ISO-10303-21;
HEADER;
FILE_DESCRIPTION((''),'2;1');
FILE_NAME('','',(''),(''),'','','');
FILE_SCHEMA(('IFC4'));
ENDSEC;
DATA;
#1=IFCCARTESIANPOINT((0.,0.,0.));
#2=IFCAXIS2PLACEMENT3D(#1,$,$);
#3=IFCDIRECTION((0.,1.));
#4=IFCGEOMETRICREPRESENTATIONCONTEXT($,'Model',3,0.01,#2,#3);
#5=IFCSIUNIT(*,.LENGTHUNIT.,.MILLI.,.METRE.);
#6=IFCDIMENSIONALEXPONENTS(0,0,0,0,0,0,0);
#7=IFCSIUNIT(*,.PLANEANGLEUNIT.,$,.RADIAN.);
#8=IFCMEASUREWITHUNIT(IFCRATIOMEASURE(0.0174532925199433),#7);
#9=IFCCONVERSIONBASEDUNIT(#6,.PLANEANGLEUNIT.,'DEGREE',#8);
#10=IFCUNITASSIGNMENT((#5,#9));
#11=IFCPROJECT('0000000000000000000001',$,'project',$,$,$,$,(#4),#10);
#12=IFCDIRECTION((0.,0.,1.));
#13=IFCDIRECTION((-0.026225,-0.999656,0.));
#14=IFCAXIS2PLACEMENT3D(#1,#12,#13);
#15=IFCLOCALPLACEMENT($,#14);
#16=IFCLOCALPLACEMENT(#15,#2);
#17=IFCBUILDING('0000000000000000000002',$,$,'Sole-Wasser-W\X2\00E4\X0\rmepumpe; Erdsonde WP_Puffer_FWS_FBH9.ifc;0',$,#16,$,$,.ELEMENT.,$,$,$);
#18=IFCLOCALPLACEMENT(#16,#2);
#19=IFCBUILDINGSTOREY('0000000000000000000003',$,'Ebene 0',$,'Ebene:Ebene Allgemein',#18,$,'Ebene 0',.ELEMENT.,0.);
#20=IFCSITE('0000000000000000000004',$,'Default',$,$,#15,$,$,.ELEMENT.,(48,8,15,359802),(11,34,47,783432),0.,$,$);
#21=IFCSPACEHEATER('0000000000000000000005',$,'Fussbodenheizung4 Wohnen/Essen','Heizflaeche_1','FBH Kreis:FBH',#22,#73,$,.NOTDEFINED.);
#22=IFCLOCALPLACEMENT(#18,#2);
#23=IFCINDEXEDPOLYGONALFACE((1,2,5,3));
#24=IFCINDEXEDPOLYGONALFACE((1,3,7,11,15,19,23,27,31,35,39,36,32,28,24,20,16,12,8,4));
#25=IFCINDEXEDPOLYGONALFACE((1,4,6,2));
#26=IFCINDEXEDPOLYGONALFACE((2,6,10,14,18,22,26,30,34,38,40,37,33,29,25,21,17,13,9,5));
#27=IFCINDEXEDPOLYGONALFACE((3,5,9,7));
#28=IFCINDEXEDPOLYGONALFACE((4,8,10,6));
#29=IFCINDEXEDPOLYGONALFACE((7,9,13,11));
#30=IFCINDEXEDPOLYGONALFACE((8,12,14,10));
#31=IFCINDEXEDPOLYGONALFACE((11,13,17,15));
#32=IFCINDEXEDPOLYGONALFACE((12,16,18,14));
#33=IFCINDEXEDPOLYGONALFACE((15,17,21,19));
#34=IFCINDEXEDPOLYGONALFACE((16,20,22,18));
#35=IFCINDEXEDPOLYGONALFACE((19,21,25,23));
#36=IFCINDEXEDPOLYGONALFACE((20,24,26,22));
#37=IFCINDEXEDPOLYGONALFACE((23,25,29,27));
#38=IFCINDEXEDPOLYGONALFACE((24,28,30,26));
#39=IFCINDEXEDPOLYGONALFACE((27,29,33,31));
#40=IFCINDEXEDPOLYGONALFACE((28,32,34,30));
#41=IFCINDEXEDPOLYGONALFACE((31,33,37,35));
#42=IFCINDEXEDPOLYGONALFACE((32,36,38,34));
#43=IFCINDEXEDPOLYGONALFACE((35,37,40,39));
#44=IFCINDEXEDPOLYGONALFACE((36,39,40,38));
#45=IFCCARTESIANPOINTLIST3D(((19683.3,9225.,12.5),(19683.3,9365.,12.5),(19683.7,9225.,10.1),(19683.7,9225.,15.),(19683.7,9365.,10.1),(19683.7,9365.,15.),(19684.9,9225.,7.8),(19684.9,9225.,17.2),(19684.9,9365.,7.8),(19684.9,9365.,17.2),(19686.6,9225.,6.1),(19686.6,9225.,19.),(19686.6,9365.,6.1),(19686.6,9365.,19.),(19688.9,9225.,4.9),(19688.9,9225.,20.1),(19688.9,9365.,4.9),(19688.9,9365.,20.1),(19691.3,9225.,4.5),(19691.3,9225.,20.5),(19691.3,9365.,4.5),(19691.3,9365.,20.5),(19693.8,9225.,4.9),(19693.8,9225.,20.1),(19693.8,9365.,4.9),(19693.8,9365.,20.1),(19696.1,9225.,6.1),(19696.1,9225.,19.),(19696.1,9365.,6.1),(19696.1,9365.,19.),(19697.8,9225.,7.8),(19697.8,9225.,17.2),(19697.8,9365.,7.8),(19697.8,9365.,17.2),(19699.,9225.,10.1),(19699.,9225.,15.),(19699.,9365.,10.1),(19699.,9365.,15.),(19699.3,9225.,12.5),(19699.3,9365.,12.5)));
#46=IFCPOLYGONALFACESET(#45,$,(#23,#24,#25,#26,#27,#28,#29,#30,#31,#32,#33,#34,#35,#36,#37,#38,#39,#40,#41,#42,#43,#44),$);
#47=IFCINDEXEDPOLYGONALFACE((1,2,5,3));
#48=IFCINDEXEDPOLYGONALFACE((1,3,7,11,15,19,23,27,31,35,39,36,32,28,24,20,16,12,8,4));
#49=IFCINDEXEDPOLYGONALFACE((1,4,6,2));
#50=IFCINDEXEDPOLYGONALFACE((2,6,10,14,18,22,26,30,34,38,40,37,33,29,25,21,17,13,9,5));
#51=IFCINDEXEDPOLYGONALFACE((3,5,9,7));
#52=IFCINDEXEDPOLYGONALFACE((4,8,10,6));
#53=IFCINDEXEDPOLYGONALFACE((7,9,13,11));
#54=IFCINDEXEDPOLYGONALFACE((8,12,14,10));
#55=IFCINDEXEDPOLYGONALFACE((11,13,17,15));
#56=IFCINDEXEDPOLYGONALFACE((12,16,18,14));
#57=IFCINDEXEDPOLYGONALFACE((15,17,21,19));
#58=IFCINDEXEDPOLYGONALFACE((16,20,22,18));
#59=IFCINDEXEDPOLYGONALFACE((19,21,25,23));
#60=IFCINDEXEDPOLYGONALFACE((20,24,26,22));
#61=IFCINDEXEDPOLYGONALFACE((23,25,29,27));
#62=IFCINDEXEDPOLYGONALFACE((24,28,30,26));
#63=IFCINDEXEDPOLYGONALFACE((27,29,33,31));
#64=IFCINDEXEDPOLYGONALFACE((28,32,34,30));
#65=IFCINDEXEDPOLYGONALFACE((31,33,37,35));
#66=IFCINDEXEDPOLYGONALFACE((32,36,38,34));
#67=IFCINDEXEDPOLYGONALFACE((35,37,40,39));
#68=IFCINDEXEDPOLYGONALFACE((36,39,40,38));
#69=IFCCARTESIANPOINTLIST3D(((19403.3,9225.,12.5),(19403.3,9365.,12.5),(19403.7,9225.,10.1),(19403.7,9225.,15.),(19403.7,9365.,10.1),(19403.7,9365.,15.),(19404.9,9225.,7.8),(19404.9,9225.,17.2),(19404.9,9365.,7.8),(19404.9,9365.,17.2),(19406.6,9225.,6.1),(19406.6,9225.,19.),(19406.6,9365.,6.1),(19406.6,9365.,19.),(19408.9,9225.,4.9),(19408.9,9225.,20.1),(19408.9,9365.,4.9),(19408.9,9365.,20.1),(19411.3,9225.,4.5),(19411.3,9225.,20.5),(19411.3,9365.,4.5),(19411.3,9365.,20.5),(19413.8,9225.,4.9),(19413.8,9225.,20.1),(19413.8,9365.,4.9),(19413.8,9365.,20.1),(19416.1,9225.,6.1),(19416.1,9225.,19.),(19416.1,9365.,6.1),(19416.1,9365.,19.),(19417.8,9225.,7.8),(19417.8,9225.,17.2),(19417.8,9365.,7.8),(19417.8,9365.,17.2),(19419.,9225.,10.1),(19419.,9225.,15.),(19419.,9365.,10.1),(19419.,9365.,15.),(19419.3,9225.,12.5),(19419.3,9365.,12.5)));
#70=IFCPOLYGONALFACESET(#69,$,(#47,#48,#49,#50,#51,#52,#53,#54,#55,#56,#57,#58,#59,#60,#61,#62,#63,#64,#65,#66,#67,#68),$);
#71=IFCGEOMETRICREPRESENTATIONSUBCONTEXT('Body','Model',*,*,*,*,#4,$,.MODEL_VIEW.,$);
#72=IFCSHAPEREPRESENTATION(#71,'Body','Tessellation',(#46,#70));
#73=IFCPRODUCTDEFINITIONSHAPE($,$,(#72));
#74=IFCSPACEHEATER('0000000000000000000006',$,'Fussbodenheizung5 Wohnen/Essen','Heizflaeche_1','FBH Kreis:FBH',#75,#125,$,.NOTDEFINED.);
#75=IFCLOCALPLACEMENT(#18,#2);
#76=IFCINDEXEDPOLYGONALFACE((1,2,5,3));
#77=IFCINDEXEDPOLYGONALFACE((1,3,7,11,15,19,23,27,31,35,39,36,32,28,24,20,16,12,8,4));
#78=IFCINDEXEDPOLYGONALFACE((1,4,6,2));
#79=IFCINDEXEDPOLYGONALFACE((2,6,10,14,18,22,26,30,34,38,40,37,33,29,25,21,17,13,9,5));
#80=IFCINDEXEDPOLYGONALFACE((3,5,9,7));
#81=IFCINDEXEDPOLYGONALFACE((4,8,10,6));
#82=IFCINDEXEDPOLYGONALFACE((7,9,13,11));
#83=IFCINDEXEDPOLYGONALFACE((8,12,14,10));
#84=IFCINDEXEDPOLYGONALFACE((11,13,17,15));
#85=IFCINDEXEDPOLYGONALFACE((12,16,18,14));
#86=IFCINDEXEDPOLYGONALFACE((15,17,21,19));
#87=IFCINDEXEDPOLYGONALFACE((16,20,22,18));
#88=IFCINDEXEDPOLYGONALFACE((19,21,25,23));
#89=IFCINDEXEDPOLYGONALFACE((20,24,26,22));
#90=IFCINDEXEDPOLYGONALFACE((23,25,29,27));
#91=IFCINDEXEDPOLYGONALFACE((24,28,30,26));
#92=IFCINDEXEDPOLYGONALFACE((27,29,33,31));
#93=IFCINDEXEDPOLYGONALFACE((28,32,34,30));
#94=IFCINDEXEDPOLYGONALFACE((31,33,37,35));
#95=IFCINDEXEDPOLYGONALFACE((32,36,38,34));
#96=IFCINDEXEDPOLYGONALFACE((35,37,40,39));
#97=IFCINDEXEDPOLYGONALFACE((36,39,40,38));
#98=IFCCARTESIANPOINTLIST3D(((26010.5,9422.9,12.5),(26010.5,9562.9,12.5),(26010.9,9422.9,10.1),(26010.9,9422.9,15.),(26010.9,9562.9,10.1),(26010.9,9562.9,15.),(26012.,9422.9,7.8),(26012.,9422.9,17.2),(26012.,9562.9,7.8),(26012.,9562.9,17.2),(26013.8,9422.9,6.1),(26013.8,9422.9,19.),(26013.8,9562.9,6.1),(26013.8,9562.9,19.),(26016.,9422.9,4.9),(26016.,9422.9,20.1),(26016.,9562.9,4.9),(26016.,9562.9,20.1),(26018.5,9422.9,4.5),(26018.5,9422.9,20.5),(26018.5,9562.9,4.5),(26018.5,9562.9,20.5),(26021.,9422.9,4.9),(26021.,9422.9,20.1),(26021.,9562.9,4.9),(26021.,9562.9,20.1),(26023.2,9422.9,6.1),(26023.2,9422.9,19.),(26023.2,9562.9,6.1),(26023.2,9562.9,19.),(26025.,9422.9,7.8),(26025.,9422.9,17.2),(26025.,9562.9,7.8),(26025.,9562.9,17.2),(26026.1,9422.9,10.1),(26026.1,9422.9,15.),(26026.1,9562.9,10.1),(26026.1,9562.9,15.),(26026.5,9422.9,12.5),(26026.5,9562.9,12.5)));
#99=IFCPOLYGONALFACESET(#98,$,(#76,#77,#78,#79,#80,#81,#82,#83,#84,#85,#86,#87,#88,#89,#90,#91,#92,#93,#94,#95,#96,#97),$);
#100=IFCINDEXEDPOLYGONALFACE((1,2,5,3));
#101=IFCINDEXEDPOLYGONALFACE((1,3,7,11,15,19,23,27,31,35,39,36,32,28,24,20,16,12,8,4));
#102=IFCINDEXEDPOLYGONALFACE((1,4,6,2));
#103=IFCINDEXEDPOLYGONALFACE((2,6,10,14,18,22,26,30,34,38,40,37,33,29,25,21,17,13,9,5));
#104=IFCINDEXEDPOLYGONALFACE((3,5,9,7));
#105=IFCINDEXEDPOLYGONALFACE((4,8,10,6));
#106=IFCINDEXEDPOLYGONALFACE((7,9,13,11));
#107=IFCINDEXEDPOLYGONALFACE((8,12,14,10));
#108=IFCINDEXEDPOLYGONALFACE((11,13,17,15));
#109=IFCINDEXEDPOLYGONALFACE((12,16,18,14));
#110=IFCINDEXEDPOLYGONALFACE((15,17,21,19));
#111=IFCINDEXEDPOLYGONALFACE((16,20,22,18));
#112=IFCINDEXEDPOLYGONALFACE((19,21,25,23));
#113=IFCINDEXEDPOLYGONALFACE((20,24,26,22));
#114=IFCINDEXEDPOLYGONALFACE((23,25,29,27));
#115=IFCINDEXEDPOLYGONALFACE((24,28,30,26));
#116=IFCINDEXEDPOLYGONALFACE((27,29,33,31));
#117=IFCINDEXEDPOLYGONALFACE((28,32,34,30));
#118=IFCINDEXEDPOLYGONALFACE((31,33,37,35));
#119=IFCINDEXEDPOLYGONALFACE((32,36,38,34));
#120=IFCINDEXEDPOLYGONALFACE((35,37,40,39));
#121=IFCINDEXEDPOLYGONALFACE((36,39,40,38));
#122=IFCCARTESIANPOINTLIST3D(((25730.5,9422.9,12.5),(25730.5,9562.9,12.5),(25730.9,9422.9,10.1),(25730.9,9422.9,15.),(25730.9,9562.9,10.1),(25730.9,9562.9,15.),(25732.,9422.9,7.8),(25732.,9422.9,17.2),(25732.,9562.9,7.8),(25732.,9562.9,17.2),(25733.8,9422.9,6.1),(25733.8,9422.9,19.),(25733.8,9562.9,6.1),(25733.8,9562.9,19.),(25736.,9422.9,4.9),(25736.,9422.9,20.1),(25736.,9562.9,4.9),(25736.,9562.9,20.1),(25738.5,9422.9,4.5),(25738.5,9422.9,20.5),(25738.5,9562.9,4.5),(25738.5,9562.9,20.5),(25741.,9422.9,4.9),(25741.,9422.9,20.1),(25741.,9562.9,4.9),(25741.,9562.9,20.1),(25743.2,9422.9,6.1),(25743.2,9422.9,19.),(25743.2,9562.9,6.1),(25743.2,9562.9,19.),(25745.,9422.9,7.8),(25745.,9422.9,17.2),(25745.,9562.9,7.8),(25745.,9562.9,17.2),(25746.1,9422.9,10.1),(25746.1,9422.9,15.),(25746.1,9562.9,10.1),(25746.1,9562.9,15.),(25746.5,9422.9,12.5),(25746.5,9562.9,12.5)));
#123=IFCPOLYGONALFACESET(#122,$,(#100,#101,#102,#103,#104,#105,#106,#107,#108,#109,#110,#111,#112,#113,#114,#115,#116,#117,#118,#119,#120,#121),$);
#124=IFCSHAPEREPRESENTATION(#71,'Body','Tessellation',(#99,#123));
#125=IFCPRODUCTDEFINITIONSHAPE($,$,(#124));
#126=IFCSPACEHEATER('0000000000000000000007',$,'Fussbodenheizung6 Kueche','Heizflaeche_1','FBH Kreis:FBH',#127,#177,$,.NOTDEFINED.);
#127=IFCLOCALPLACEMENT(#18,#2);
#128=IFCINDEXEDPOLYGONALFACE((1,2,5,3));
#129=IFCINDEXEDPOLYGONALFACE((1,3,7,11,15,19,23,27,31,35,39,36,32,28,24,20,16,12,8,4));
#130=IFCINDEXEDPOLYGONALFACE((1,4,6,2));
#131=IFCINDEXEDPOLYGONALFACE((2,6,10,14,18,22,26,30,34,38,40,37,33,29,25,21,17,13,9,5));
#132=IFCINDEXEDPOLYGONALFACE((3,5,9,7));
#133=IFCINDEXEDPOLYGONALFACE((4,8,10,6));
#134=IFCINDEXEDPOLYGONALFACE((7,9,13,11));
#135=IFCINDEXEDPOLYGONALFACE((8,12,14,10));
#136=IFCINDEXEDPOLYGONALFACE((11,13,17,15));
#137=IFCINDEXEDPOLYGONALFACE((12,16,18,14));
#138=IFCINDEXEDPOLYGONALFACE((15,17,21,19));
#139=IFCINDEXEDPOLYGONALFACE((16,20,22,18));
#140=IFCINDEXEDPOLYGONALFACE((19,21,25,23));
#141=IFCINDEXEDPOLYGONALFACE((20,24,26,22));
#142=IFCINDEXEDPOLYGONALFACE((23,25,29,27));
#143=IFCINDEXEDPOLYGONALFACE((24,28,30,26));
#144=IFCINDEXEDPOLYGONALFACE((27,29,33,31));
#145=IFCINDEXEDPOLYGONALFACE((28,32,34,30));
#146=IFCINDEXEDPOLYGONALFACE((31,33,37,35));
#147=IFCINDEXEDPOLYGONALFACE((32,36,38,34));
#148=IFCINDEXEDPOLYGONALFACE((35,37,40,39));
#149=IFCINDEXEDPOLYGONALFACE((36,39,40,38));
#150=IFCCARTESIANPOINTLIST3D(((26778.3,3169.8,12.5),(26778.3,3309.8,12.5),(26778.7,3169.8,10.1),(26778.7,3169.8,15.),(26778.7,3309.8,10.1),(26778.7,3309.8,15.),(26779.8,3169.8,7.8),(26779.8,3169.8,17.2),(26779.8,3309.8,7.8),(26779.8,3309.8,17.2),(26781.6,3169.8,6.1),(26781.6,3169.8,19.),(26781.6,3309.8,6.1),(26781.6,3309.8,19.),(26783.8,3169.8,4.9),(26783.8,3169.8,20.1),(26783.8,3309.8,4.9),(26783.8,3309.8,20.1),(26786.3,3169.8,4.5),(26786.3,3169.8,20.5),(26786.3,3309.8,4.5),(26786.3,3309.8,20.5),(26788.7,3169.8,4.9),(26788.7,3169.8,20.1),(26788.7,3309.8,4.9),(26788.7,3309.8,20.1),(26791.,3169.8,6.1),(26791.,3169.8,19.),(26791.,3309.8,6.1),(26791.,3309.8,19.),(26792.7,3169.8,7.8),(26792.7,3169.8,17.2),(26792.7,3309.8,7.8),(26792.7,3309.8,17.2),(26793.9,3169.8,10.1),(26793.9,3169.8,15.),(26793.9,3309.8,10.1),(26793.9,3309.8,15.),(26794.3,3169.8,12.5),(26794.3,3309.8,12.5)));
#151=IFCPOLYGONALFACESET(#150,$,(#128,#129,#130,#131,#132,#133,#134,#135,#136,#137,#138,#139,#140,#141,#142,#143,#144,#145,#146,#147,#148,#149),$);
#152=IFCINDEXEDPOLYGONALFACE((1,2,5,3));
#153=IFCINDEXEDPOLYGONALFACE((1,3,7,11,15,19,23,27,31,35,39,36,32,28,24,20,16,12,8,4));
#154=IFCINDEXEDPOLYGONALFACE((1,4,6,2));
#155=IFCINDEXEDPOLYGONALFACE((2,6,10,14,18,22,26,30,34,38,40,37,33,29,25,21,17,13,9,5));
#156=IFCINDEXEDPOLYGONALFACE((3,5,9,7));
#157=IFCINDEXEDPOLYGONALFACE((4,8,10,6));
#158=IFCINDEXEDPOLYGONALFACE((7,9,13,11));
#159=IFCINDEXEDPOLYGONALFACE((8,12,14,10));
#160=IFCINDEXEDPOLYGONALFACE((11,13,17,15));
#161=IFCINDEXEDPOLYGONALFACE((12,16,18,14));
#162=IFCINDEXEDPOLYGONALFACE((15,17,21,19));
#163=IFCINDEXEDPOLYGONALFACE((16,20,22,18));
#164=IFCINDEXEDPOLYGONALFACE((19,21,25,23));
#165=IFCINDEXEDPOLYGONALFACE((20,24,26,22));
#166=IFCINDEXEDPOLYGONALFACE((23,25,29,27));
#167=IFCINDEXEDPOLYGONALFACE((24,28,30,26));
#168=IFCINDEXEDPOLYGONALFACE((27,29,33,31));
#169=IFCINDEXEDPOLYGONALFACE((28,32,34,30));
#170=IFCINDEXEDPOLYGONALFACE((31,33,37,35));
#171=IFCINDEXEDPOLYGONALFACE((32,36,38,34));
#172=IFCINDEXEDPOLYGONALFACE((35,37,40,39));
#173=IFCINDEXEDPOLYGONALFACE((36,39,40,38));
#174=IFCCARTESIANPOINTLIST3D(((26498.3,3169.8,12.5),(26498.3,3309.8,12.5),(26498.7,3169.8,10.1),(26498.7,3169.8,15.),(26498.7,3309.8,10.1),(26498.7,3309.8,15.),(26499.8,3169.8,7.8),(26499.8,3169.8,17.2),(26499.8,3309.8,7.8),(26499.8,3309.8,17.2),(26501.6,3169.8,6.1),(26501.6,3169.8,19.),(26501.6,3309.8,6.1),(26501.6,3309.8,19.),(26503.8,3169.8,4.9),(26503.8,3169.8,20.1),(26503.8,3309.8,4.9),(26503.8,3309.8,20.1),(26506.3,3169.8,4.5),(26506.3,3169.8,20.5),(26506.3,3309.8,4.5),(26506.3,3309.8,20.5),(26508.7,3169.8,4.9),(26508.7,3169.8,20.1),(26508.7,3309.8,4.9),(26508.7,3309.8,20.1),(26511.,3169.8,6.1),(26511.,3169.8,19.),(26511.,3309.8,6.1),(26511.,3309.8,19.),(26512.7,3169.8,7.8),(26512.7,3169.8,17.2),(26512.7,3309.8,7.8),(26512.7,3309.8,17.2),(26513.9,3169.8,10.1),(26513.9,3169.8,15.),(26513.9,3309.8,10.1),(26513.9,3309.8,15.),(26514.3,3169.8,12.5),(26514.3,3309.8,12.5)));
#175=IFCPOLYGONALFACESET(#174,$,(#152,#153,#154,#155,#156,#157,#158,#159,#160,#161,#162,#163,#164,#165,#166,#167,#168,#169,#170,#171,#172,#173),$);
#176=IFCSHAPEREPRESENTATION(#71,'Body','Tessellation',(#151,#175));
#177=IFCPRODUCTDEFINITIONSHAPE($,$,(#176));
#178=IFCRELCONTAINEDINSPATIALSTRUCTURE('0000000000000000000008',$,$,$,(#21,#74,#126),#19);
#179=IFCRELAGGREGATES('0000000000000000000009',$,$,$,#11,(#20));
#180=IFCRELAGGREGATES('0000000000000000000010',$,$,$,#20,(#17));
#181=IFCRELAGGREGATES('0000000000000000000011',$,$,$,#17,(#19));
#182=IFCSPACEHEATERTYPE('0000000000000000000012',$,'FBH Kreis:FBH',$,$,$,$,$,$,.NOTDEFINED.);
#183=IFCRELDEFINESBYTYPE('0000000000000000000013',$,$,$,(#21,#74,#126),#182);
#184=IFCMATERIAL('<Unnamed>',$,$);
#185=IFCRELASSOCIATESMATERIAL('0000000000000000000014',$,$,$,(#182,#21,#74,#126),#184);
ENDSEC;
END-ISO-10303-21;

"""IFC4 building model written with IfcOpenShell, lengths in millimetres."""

from ifc_helpers import new_model, entity, si_unit, converted_unit, direction, frame, origin, place, context, subcontext, project, spatial, indexed_curve, outline, extrude, source, transform, mapped, material, type_object, type_shapes, element, save


model = new_model("IFC4")

# Units and contexts
model_context = context("Model", 3, precision=0.01, world=origin(), true_north=direction((0.0, 1.0)))
body_context = subcontext(model_context, "Body", "Model", "MODEL_VIEW")
ifc_project = project(units=[si_unit("LENGTHUNIT", "METRE", prefix="MILLI"), converted_unit("PLANEANGLEUNIT", "DEGREE", entity("IfcRatioMeasure", 0.0174532925199433), si_unit("PLANEANGLEUNIT", "RADIAN"), dimensions=[0, 0, 0, 0, 0, 0, 0])], contexts=[model_context])

# Site, building, storey
site_placement = place(None, frame((0.0, 0.0, 0.0), z_axis=(0.0, 0.0, 1.0), x_axis=(-0.026225, -0.999656, 0.0)))
site = spatial("IfcSite", under=ifc_project, at=site_placement, Name="Default", CompositionType="ELEMENT", RefLatitude=(48, 8, 15, 359802), RefLongitude=(11, 34, 47, 783432), RefElevation=0.0)
building_placement = place(site_placement, origin())
building = spatial("IfcBuilding", under=site, at=building_placement, Description="Sole-Wasser-Wärmepumpe; Erdsonde WP_Puffer_FWS_FBH9.ifc;0", CompositionType="ELEMENT")
storey_placement = place(building_placement, origin())
storey = spatial("IfcBuildingStorey", under=building, at=storey_placement, Name="Ebene 0", ObjectType="Ebene:Ebene Allgemein", LongName="Ebene 0", CompositionType="ELEMENT", Elevation=0.0)

# Space heaters
ifc_material = material(Name="<Unnamed>")
space_heater_type = type_object("IfcSpaceHeaterType", Name="FBH Kreis:FBH", PredefinedType="NOTDEFINED", material=ifc_material)
shared_shape = source(origin(), body_context, "Body", "SweptSolid", [
    extrude(outline(indexed_curve([(8.0, 0.0), (7.6, 2.5), (6.5, 4.7), (4.7, 6.5), (2.5, 7.6), (0.0, 8.0), (-2.5, 7.6), (-4.7, 6.5), (-6.5, 4.7), (-7.6, 2.5), (-8.0, 0.0), (-7.6, -2.5), (-6.5, -4.7), (-4.7, -6.5), (-2.5, -7.6), (0.0, -8.0), (2.5, -7.6), (4.7, -6.5), (6.5, -4.7), (7.6, -2.5), (8.0, 0.0)], self_intersect=False)), frame((140.0, -1621.8, -83.0), z_axis=(0.0, 1.0, 0.0), x_axis=(1.0, 0.0, 0.0)), (0.0, 0.0, 1.0), 140.0),
    extrude(outline(indexed_curve([(8.0, 0.0), (7.6, 2.5), (6.5, 4.7), (4.7, 6.5), (2.5, 7.6), (0.0, 8.0), (-2.5, 7.6), (-4.7, 6.5), (-6.5, 4.7), (-7.6, 2.5), (-8.0, 0.0), (-7.6, -2.5), (-6.5, -4.7), (-4.7, -6.5), (-2.5, -7.6), (0.0, -8.0), (2.5, -7.6), (4.7, -6.5), (6.5, -4.7), (7.6, -2.5), (8.0, 0.0)], self_intersect=False)), frame((-140.0, -1621.8, -83.0), z_axis=(0.0, 1.0, 0.0), x_axis=(1.0, 0.0, 0.0)), (0.0, 0.0, 1.0), 140.0),
])
type_shapes(space_heater_type, [shared_shape])
for number, where, name in (
    (1, (19551.3, 10846.8, 95.5), "Fussbodenheizung4 Wohnen/Essen"),
    (2, (25878.5, 11044.6, 95.5), "Fussbodenheizung5 Wohnen/Essen"),
    (3, (26646.3, 4791.6, 95.5), "Fussbodenheizung6 Kueche"),
):
    element("IfcSpaceHeater", number, at=place(storey_placement, frame(where)), inside=storey, type_object=space_heater_type, material=ifc_material, Name=name, Description="Heizflaeche_1", ObjectType="FBH Kreis:FBH", PredefinedType="NOTDEFINED", context=body_context, shape_type="MappedRepresentation", body=[
        mapped(shared_shape, transform((0.0, 0.0, 0.0), scale=1.0)),
    ])

save(model, "model.ifc")
